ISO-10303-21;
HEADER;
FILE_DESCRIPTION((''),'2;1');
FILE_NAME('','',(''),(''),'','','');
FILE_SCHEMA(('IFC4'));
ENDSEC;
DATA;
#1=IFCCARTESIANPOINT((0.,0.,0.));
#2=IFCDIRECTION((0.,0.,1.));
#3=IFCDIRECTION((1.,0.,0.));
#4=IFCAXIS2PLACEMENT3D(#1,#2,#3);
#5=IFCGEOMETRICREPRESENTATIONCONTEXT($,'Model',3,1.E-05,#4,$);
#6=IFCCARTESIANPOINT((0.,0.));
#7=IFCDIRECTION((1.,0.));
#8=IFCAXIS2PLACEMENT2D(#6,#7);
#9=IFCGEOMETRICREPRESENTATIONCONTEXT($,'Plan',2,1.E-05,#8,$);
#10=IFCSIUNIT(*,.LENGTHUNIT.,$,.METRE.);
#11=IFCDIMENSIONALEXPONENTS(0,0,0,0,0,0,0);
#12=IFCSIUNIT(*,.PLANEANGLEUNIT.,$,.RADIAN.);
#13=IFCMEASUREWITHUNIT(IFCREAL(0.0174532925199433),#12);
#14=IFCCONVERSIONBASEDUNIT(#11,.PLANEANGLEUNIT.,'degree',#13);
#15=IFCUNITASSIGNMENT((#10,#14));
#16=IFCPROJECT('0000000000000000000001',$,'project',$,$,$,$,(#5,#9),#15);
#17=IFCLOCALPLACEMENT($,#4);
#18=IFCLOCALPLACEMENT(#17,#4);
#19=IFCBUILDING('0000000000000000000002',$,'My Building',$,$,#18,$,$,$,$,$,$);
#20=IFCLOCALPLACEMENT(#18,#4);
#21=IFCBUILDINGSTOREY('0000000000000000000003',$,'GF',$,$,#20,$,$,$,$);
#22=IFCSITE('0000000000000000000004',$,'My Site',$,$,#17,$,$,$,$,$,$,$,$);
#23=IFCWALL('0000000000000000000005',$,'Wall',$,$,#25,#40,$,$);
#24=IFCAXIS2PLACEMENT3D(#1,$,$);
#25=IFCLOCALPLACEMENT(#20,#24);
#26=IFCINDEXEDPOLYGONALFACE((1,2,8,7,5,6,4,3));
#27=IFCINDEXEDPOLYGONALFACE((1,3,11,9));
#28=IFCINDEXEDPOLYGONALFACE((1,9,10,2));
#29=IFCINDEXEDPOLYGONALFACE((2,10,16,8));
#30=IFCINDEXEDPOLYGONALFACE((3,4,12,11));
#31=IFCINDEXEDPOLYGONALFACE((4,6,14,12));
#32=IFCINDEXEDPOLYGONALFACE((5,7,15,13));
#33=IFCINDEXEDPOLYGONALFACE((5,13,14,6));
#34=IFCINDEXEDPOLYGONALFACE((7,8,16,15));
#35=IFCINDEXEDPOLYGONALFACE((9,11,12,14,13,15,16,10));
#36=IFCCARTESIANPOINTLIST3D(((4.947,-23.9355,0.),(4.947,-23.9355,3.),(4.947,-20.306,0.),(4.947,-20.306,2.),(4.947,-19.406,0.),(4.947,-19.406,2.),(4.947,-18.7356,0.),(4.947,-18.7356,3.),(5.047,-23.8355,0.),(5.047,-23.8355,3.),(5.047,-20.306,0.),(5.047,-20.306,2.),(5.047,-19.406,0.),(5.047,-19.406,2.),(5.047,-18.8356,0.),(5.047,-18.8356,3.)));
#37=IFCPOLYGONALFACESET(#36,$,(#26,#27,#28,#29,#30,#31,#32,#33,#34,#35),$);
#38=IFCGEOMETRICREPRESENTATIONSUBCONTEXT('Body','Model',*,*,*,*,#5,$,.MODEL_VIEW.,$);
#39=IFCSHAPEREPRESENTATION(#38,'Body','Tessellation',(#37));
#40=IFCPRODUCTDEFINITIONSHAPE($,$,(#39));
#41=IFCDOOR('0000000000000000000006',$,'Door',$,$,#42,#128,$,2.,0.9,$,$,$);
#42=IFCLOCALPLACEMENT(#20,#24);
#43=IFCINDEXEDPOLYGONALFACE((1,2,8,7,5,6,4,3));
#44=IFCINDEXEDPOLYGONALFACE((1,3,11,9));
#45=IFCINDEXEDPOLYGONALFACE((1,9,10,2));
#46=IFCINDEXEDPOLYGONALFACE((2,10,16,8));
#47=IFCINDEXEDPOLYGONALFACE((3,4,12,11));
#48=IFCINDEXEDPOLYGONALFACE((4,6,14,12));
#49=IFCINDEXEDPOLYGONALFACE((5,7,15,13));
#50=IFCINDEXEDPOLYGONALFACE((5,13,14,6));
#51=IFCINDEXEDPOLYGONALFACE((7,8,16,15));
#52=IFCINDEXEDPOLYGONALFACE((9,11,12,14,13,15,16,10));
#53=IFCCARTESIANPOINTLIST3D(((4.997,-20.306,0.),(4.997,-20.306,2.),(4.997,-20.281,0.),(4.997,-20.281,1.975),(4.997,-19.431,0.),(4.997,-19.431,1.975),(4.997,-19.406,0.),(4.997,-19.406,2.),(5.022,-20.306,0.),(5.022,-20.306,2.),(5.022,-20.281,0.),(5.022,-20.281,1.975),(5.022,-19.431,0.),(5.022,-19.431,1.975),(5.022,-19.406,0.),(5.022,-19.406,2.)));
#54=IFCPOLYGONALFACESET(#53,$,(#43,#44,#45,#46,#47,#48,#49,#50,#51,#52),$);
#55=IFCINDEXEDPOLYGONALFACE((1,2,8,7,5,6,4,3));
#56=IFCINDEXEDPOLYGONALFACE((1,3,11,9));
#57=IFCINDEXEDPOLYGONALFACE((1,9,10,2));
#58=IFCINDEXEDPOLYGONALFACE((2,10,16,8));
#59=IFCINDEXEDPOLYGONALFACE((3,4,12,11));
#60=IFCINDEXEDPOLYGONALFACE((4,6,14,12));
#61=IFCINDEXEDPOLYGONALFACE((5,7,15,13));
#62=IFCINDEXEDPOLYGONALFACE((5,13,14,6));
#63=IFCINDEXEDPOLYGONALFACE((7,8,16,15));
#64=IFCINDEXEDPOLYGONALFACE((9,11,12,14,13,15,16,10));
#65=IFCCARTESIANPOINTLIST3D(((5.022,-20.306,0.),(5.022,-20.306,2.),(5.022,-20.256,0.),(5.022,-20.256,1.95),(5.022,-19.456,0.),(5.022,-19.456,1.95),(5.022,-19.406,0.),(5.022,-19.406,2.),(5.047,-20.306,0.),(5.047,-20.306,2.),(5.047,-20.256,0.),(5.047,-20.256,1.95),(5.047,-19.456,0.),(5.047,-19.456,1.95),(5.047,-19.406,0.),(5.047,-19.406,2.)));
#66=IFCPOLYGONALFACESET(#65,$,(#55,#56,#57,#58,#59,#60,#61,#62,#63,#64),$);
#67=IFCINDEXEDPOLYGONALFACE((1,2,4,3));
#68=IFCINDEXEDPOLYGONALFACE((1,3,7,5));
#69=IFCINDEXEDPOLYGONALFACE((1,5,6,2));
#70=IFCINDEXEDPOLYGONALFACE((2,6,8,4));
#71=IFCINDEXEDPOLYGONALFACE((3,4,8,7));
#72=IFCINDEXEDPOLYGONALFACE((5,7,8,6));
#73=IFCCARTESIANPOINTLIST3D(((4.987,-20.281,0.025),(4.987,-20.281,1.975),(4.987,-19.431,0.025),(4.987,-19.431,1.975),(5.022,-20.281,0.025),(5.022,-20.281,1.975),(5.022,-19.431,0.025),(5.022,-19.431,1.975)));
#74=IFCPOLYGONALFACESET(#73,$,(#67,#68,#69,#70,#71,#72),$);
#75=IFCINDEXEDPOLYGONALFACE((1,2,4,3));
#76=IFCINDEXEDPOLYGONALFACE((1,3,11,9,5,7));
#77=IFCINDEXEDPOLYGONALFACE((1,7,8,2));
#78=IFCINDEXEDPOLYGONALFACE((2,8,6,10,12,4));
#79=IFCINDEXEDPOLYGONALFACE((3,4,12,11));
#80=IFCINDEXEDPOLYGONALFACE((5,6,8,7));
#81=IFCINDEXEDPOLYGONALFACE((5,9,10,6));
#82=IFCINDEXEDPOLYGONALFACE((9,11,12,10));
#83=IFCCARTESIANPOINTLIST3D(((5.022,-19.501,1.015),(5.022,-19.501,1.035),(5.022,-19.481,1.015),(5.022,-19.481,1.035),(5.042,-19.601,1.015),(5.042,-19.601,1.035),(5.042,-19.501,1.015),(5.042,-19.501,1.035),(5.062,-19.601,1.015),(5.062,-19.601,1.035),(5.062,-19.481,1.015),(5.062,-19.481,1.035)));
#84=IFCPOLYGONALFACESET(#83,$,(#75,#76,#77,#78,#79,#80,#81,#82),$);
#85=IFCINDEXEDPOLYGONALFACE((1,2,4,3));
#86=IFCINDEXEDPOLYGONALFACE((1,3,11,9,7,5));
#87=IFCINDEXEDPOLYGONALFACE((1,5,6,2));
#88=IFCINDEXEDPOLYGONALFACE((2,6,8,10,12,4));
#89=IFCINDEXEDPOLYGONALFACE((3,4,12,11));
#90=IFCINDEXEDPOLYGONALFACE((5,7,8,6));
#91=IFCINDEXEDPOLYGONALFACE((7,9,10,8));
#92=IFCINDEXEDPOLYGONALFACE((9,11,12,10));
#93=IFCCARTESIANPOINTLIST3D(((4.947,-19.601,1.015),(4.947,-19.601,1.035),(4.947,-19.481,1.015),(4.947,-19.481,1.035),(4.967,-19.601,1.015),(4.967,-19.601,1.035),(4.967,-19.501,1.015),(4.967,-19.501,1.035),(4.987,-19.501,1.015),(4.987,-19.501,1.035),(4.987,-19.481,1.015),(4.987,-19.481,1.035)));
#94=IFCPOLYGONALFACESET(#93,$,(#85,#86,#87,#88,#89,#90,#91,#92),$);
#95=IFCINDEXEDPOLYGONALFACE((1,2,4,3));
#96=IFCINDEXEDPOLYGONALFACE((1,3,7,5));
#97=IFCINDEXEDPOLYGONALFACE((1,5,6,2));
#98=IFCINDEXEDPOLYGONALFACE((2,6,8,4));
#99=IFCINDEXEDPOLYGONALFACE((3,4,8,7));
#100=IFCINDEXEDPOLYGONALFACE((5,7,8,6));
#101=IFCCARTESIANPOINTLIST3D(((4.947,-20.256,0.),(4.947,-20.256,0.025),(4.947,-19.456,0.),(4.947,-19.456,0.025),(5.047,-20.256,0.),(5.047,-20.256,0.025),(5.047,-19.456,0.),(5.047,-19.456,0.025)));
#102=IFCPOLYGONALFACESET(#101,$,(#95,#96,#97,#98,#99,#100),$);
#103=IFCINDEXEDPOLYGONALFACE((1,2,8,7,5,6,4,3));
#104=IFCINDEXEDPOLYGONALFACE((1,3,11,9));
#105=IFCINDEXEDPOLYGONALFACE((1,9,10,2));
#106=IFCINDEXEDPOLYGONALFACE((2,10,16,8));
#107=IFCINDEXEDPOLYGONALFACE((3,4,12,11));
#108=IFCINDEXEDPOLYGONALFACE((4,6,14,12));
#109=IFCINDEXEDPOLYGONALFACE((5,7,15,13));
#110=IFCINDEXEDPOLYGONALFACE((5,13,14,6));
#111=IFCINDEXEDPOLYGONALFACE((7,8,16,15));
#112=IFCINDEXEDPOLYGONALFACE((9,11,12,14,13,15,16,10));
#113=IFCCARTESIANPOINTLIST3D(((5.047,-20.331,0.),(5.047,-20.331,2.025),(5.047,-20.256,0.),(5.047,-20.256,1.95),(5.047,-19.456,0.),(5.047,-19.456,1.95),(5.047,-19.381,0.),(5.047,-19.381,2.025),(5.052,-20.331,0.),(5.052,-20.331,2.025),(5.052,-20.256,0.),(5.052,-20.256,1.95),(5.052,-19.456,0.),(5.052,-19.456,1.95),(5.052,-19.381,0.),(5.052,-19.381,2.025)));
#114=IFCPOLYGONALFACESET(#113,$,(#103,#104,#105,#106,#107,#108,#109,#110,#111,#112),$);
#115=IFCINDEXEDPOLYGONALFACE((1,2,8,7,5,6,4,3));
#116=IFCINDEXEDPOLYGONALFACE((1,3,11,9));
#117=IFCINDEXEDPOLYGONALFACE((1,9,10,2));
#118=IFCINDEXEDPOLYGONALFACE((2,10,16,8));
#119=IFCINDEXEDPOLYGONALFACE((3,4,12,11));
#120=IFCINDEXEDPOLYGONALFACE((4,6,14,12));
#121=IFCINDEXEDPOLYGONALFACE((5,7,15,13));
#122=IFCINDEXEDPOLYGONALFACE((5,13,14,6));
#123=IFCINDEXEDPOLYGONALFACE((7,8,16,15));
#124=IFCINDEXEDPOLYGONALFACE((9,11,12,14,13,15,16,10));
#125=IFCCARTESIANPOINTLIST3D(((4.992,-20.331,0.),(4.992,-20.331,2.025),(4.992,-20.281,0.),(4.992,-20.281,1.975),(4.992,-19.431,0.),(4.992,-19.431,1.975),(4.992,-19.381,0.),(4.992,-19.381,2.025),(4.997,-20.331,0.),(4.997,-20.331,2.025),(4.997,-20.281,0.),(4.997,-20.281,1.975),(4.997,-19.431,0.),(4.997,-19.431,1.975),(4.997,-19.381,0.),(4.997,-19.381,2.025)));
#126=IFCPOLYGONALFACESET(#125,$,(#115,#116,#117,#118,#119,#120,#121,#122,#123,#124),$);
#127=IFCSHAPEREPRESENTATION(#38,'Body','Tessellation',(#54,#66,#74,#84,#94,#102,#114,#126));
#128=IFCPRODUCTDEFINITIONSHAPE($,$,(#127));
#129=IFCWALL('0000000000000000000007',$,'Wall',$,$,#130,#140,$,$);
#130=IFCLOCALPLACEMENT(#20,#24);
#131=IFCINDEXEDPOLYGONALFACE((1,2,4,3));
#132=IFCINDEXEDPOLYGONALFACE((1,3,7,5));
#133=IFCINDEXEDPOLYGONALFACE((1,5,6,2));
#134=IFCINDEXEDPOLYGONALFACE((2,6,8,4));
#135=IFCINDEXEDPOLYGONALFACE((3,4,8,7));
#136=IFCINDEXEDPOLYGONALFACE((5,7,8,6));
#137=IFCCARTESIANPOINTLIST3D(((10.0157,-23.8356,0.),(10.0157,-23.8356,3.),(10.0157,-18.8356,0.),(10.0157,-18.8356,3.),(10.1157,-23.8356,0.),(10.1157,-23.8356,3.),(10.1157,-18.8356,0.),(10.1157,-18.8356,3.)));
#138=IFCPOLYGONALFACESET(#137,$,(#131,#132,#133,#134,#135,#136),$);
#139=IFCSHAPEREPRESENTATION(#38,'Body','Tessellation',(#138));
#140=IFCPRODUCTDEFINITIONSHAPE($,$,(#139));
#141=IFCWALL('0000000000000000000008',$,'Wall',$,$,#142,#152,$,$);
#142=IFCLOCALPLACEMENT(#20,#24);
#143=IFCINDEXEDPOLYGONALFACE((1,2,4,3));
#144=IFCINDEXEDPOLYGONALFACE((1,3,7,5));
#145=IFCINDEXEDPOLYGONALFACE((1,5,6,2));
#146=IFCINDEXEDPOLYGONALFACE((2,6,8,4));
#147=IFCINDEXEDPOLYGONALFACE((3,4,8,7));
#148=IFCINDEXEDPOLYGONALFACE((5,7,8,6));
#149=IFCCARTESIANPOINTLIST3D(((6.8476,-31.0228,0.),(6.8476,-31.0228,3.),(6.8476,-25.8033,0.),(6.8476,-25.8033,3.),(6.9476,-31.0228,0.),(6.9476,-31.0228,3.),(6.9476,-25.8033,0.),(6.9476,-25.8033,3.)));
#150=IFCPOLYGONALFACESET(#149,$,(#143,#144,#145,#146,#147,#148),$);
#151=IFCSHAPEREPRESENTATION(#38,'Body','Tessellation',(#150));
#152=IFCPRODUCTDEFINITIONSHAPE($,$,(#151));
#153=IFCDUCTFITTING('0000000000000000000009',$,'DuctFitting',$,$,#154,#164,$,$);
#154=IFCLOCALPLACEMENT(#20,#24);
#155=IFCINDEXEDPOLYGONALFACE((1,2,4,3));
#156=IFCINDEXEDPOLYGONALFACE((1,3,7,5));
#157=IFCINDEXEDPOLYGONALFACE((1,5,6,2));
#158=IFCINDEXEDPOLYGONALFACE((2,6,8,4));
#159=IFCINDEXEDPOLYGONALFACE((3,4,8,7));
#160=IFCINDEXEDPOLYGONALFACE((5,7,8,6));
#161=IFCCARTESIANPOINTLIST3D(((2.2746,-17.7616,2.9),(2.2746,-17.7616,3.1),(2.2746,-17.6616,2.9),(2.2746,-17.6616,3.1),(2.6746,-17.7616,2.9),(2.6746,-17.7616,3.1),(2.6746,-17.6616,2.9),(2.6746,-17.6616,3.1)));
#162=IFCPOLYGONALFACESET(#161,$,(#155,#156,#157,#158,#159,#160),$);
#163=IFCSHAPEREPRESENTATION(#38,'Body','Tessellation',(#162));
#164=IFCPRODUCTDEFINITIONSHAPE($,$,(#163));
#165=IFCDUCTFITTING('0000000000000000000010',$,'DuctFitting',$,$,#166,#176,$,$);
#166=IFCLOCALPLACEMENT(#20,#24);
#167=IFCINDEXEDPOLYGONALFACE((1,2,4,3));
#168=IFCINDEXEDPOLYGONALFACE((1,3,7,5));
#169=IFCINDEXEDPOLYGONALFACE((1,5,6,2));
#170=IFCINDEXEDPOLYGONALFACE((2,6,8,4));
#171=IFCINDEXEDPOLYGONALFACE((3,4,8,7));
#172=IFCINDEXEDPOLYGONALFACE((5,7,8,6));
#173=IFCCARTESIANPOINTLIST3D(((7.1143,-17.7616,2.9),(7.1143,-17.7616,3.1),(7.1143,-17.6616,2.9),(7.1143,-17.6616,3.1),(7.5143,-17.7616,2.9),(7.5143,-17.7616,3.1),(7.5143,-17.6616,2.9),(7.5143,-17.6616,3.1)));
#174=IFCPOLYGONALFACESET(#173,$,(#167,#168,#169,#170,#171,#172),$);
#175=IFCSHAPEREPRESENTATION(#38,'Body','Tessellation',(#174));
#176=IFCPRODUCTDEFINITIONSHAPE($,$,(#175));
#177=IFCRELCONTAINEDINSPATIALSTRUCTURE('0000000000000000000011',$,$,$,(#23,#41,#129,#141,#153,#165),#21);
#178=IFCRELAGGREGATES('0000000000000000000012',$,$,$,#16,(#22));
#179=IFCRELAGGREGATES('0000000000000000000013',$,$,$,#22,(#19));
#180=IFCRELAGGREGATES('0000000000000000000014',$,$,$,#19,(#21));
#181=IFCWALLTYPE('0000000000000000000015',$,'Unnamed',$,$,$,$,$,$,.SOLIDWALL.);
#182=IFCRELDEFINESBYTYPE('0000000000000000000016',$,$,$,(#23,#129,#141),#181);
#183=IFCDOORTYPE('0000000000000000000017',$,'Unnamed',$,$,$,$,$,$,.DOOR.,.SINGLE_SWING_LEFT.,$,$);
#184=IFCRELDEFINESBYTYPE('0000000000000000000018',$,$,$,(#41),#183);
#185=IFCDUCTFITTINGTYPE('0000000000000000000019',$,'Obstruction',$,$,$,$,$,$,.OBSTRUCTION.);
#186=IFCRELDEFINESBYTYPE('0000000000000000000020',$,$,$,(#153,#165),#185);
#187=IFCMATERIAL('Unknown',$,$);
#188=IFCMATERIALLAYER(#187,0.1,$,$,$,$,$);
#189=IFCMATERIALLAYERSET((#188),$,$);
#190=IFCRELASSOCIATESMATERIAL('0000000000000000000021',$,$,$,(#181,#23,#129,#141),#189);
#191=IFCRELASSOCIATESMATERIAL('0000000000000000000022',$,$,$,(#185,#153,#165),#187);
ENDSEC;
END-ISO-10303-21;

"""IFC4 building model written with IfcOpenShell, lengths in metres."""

from ifc_helpers import new_model, entity, si_unit, converted_unit, frame, origin_with_axes, origin_2d_with_axis, place, context, subcontext, project, spatial, line, indexed_curve, rectangle, outline, extrude, shape, source, transform, mapped, material, layer, layer_set, layer_usage, material_profile, profile_set, profile_usage, type_object, type_shapes, element, fill, save


model = new_model("IFC4")

# Units and contexts
model_context = context("Model", 3, precision=1e-05, world=origin_with_axes())
plan_context = context("Plan", 2, precision=1e-05, world=origin_2d_with_axis())
body_context_1 = subcontext(model_context, "Body", "Model", "MODEL_VIEW")
body_context_2 = subcontext(plan_context, "Body", "Plan", "PLAN_VIEW")
ifc_project = project(units=[si_unit("LENGTHUNIT", "METRE"), converted_unit("PLANEANGLEUNIT", "degree", entity("IfcReal", 0.0174532925199433), si_unit("PLANEANGLEUNIT", "RADIAN"), dimensions=[0, 0, 0, 0, 0, 0, 0])], contexts=[model_context, plan_context])

# Site, building, storey
site_placement = place(None, origin_with_axes())
site = spatial("IfcSite", under=ifc_project, at=site_placement, Name="My Site")
building_placement = place(site_placement, origin_with_axes())
building = spatial("IfcBuilding", under=site, at=building_placement, Name="My Building")
storey_placement = place(building_placement, origin_with_axes())
storey = spatial("IfcBuildingStorey", under=building, at=storey_placement, Name="GF")

# Shared definitions
ifc_material = material(Name="Unknown")

# Shared definitions
ifc_layer_1 = layer(ifc_material, 0.1)
ifc_layer_set_1 = layer_set([ifc_layer_1])
wall_type = type_object("IfcWallType", Name="Unnamed", PredefinedType="SOLIDWALL", material=ifc_layer_set_1)

# Shared definitions
shared_shape_1 = source(origin_with_axes(), body_context_1, "Body", "SweptSolid", [
    extrude(outline(indexed_curve([(0.0, 0.0), (0.9, 0.0), (0.9, 2.0), (0.0, 2.0)], segments=[line(1, 2, 3, 4, 1)])), frame((0.0, -0.6, 0.0), z_axis=(0.0, -1.0, 0.0), x_axis=(1.0, 0.0, 0.0)), (0.0, 0.0, -1.0), 1.2),
])
door_type = type_object("IfcDoorType", Name="Unnamed", OperationType="SINGLE_SWING_LEFT", PredefinedType="DOOR")
shared_shape_2 = source(origin_with_axes(), body_context_1, "Body", "SweptSolid", [
    extrude(outline(indexed_curve([(0.0, 0.0), (0.0, 2.0), (0.9, 2.0), (0.9, 0.0), (0.875, 0.0), (0.875, 1.975), (0.025, 1.975), (0.025, 0.0)], segments=[line(1, 2, 3, 4, 5, 6, 7, 8, 1)])), frame((0.0, 0.025, 0.0), z_axis=(0.0, -1.0, 0.0), x_axis=(1.0, 0.0, 0.0)), (0.0, 0.0, -1.0), 0.025),
    extrude(outline(indexed_curve([(0.0, 0.0), (0.0, 2.0), (0.9, 2.0), (0.9, 0.0), (0.85, 0.0), (0.85, 1.95), (0.05, 1.95), (0.05, 0.0)], segments=[line(1, 2, 3, 4, 5, 6, 7, 8, 1)])), frame((0.0, 0.0, 0.0), z_axis=(0.0, -1.0, 0.0), x_axis=(1.0, 0.0, 0.0)), (0.0, 0.0, -1.0), 0.025),
    extrude(outline(indexed_curve([(0.0, 0.0), (0.85, 0.0), (0.85, 0.035), (0.0, 0.035)], segments=[line(1, 2, 3, 4, 1)])), frame((0.025, 0.025, 0.025), z_axis=(0.0, 0.0, 1.0), x_axis=(1.0, 0.0, 0.0)), (0.0, 0.0, 1.0), 1.95),
    extrude(outline(indexed_curve([(0.0, 0.0), (0.0, -0.04), (-0.12, -0.04), (-0.12, -0.02), (-0.02, -0.02), (-0.02, 0.0)], segments=[line(1, 2, 3, 4, 5, 6, 1)])), frame((0.825, 0.025, 1.015), z_axis=(0.0, 0.0, 1.0), x_axis=(1.0, 0.0, 0.0)), (0.0, 0.0, 1.0), 0.02),
    extrude(outline(indexed_curve([(0.0, 0.0), (0.0, 0.04), (-0.12, 0.04), (-0.12, 0.02), (-0.02, 0.02), (-0.02, 0.0)], segments=[line(1, 2, 3, 4, 5, 6, 1)])), frame((0.825, 0.06, 1.015), z_axis=(0.0, 0.0, 1.0), x_axis=(1.0, 0.0, 0.0)), (0.0, 0.0, 1.0), 0.02),
    extrude(outline(indexed_curve([(0.0, 0.0), (0.8, 0.0), (0.8, 0.1), (0.0, 0.1)], segments=[line(1, 2, 3, 4, 1)])), frame((0.05, 0.0, 0.0), z_axis=(0.0, 0.0, 1.0), x_axis=(1.0, 0.0, 0.0)), (0.0, 0.0, 1.0), 0.025),
    extrude(outline(indexed_curve([(0.0, 0.0), (0.0, 2.025), (0.95, 2.025), (0.95, 0.0), (0.875, 0.0), (0.875, 1.95), (0.075, 1.95), (0.075, 0.0)], segments=[line(1, 2, 3, 4, 5, 6, 7, 8, 1)])), frame((-0.025, -0.005, 0.0), z_axis=(0.0, -1.0, 0.0), x_axis=(1.0, 0.0, 0.0)), (0.0, 0.0, -1.0), 0.005),
    extrude(outline(indexed_curve([(0.0, 0.0), (0.0, 2.025), (0.95, 2.025), (0.95, 0.0), (0.9, 0.0), (0.9, 1.975), (0.05, 1.975), (0.05, 0.0)], segments=[line(1, 2, 3, 4, 5, 6, 7, 8, 1)])), frame((-0.025, 0.05, 0.0), z_axis=(0.0, -1.0, 0.0), x_axis=(1.0, 0.0, 0.0)), (0.0, 0.0, -1.0), 0.005),
])
shared_shape_3 = source(origin_with_axes(), body_context_2, "Body", "Curve2D", [
    entity("IfcIndexedPolyCurve", entity("IfcCartesianPointList2D", [[0.0, 0.0], [0.0, 0.05], [0.025, 0.05], [0.025, 0.025], [0.05, 0.025], [0.05, 0.0]]), [entity("IfcLineIndex", [1, 2, 3, 4, 5, 6, 1])]),
    entity("IfcIndexedPolyCurve", entity("IfcCartesianPointList2D", [[0.9, 0.0], [0.9, 0.05], [0.875, 0.05], [0.875, 0.025], [0.85, 0.025], [0.85, 0.0]]), [entity("IfcLineIndex", [1, 2, 3, 4, 5, 6, 1])]),
    entity("IfcTrimmedCurve", entity("IfcEllipse", entity("IfcAxis2Placement2D", entity("IfcCartesianPoint", [0.06, 0.05]), entity("IfcDirection", [1.0, 0.0])), 0.815, 0.85), [entity("IfcCartesianPoint", [0.875, 0.05])], [entity("IfcCartesianPoint", [0.06, 0.9])], True, "CARTESIAN"),
    entity("IfcIndexedPolyCurve", entity("IfcCartesianPointList2D", [[0.025, 0.05], [0.06, 0.05], [0.06, 0.9], [0.025, 0.9]]), [entity("IfcLineIndex", [1, 2, 3, 4, 1])]),
])
type_shapes(door_type, [shared_shape_2, shared_shape_3])

# Wall, opening, door
ifc_layer_usage_1 = layer_usage(ifc_layer_set_1, "AXIS2", "POSITIVE", 0.0)
wall_1_placement = place(storey_placement, frame((5.047, -23.8355, 0.0), z_axis=(0.0, 0.0, 1.0), x_axis=(0.0, 1.0, 0.0)))
wall_1 = element("IfcWall", 1, at=wall_1_placement, inside=storey, type_object=wall_type, material=ifc_layer_usage_1, Name="Wall", context=body_context_1, shape_type="SweptSolid", body=[
    extrude(outline(indexed_curve([(0.0, 0.0), (-0.1, 0.1), (5.1, 0.1), (5.0, 0.0)], segments=[line(1, 2, 3, 4, 1)])), origin_with_axes(), (0.0, 0.0, 1.0), 3.0),
])
opening_1_placement = place(wall_1_placement, frame((3.5295, 0.0, 0.0), z_axis=(0.0, 0.0, 1.0), x_axis=(1.0, 0.0, 0.0)))
opening_1 = element("IfcOpeningElement", 2, at=opening_1_placement, cuts=wall_1, PredefinedType="OPENING", context=body_context_1, shape_type="MappedRepresentation", body=[
    mapped(shared_shape_1, transform((0.0, 0.0, 0.0), x_axis=(1.0, 0.0, 0.0), y_axis=(0.0, 1.0, 0.0), z_axis=(0.0, 0.0, 1.0), scale=1.0)),
])
door_1_placement = place(opening_1_placement, frame((0.0, 0.0, 0.0), z_axis=(0.0, 0.0, 1.0), x_axis=(1.0, 0.0, 0.0)))
door_1 = element("IfcDoor", 3, at=door_1_placement, inside=storey, type_object=door_type, Name="Door", OverallHeight=2.0, OverallWidth=0.9, shapes=[
    shape(body_context_1, "Body", "MappedRepresentation", [mapped(shared_shape_2, transform((0.0, 0.0, 0.0), x_axis=(1.0, 0.0, 0.0), y_axis=(0.0, 1.0, 0.0), z_axis=(0.0, 0.0, 1.0), scale=1.0))]),
    shape(body_context_2, "Body", "MappedRepresentation", [mapped(shared_shape_3, transform((0.0, 0.0, 0.0), x_axis=(1.0, 0.0, 0.0), y_axis=(0.0, 1.0, 0.0), z_axis=(0.0, 0.0, 1.0), scale=1.0))]),
])
fill(opening_1, door_1)

# Walls
ifc_layer_usage_2 = layer_usage(ifc_layer_set_1, "AXIS2", "POSITIVE", 0.0)
wall_2_placement = place(storey_placement, frame((10.0157, -18.8356, 0.0), z_axis=(0.0, 0.0, 1.0), x_axis=(0.0, -1.0, 0.0)))
element("IfcWall", 4, at=wall_2_placement, inside=storey, type_object=wall_type, material=ifc_layer_usage_2, Name="Wall", context=body_context_1, shape_type="SweptSolid", body=[
    extrude(outline(indexed_curve([(0.0, 0.0), (0.0, 0.1), (5.0, 0.1), (5.0, 0.0)], segments=[line(1, 2, 3, 4, 1)])), origin_with_axes(), (0.0, 0.0, 1.0), 3.0),
])
ifc_layer_usage_3 = layer_usage(ifc_layer_set_1, "AXIS2", "POSITIVE", 0.0)
wall_3_placement = place(storey_placement, frame((6.8476, -25.8033, 0.0), z_axis=(0.0, 0.0, 1.0), x_axis=(0.0, -1.0, 0.0)))
element("IfcWall", 5, at=wall_3_placement, inside=storey, type_object=wall_type, material=ifc_layer_usage_3, Name="Wall", context=body_context_1, shape_type="SweptSolid", body=[
    extrude(outline(indexed_curve([(0.0, 0.0), (0.0, 0.1), (5.2195, 0.1), (5.2195, 0.0)], segments=[line(1, 2, 3, 4, 1)])), origin_with_axes(), (0.0, 0.0, 1.0), 3.0),
])

# Duct fittings
ifc_material_profile = material_profile(ifc_material, rectangle(XDim=0.4, YDim=0.2))
ifc_profile_set = profile_set([ifc_material_profile])
ifc_profile_usage_1 = profile_usage(ifc_profile_set, cardinal=5)
duct_fitting_type = type_object("IfcDuctFittingType", Name="Obstruction", PredefinedType="OBSTRUCTION", material=ifc_profile_set)
duct_fitting_1_placement = place(storey_placement, frame((2.4746, -17.7616, 3.0), z_axis=(0.0, 1.0, 0.0), x_axis=(-1.0, 0.0, 0.0)))
element("IfcDuctFitting", 6, at=duct_fitting_1_placement, inside=storey, type_object=duct_fitting_type, material=ifc_profile_usage_1, Name="DuctFitting", context=body_context_1, shape_type="SweptSolid", body=[
    extrude(rectangle(XDim=0.4, YDim=0.2), origin_with_axes(), (0.0, 0.0, 1.0), 0.1),
])
ifc_profile_usage_2 = profile_usage(ifc_profile_set, cardinal=5)
duct_fitting_2_placement = place(storey_placement, frame((7.3143, -17.7616, 3.0), z_axis=(0.0, 1.0, 0.0), x_axis=(-1.0, 0.0, 0.0)))
element("IfcDuctFitting", 7, at=duct_fitting_2_placement, inside=storey, type_object=duct_fitting_type, material=ifc_profile_usage_2, Name="DuctFitting", context=body_context_1, shape_type="SweptSolid", body=[
    extrude(rectangle(XDim=0.4, YDim=0.2), origin_with_axes(), (0.0, 0.0, 1.0), 0.1),
])

save(model, "model.ifc")
